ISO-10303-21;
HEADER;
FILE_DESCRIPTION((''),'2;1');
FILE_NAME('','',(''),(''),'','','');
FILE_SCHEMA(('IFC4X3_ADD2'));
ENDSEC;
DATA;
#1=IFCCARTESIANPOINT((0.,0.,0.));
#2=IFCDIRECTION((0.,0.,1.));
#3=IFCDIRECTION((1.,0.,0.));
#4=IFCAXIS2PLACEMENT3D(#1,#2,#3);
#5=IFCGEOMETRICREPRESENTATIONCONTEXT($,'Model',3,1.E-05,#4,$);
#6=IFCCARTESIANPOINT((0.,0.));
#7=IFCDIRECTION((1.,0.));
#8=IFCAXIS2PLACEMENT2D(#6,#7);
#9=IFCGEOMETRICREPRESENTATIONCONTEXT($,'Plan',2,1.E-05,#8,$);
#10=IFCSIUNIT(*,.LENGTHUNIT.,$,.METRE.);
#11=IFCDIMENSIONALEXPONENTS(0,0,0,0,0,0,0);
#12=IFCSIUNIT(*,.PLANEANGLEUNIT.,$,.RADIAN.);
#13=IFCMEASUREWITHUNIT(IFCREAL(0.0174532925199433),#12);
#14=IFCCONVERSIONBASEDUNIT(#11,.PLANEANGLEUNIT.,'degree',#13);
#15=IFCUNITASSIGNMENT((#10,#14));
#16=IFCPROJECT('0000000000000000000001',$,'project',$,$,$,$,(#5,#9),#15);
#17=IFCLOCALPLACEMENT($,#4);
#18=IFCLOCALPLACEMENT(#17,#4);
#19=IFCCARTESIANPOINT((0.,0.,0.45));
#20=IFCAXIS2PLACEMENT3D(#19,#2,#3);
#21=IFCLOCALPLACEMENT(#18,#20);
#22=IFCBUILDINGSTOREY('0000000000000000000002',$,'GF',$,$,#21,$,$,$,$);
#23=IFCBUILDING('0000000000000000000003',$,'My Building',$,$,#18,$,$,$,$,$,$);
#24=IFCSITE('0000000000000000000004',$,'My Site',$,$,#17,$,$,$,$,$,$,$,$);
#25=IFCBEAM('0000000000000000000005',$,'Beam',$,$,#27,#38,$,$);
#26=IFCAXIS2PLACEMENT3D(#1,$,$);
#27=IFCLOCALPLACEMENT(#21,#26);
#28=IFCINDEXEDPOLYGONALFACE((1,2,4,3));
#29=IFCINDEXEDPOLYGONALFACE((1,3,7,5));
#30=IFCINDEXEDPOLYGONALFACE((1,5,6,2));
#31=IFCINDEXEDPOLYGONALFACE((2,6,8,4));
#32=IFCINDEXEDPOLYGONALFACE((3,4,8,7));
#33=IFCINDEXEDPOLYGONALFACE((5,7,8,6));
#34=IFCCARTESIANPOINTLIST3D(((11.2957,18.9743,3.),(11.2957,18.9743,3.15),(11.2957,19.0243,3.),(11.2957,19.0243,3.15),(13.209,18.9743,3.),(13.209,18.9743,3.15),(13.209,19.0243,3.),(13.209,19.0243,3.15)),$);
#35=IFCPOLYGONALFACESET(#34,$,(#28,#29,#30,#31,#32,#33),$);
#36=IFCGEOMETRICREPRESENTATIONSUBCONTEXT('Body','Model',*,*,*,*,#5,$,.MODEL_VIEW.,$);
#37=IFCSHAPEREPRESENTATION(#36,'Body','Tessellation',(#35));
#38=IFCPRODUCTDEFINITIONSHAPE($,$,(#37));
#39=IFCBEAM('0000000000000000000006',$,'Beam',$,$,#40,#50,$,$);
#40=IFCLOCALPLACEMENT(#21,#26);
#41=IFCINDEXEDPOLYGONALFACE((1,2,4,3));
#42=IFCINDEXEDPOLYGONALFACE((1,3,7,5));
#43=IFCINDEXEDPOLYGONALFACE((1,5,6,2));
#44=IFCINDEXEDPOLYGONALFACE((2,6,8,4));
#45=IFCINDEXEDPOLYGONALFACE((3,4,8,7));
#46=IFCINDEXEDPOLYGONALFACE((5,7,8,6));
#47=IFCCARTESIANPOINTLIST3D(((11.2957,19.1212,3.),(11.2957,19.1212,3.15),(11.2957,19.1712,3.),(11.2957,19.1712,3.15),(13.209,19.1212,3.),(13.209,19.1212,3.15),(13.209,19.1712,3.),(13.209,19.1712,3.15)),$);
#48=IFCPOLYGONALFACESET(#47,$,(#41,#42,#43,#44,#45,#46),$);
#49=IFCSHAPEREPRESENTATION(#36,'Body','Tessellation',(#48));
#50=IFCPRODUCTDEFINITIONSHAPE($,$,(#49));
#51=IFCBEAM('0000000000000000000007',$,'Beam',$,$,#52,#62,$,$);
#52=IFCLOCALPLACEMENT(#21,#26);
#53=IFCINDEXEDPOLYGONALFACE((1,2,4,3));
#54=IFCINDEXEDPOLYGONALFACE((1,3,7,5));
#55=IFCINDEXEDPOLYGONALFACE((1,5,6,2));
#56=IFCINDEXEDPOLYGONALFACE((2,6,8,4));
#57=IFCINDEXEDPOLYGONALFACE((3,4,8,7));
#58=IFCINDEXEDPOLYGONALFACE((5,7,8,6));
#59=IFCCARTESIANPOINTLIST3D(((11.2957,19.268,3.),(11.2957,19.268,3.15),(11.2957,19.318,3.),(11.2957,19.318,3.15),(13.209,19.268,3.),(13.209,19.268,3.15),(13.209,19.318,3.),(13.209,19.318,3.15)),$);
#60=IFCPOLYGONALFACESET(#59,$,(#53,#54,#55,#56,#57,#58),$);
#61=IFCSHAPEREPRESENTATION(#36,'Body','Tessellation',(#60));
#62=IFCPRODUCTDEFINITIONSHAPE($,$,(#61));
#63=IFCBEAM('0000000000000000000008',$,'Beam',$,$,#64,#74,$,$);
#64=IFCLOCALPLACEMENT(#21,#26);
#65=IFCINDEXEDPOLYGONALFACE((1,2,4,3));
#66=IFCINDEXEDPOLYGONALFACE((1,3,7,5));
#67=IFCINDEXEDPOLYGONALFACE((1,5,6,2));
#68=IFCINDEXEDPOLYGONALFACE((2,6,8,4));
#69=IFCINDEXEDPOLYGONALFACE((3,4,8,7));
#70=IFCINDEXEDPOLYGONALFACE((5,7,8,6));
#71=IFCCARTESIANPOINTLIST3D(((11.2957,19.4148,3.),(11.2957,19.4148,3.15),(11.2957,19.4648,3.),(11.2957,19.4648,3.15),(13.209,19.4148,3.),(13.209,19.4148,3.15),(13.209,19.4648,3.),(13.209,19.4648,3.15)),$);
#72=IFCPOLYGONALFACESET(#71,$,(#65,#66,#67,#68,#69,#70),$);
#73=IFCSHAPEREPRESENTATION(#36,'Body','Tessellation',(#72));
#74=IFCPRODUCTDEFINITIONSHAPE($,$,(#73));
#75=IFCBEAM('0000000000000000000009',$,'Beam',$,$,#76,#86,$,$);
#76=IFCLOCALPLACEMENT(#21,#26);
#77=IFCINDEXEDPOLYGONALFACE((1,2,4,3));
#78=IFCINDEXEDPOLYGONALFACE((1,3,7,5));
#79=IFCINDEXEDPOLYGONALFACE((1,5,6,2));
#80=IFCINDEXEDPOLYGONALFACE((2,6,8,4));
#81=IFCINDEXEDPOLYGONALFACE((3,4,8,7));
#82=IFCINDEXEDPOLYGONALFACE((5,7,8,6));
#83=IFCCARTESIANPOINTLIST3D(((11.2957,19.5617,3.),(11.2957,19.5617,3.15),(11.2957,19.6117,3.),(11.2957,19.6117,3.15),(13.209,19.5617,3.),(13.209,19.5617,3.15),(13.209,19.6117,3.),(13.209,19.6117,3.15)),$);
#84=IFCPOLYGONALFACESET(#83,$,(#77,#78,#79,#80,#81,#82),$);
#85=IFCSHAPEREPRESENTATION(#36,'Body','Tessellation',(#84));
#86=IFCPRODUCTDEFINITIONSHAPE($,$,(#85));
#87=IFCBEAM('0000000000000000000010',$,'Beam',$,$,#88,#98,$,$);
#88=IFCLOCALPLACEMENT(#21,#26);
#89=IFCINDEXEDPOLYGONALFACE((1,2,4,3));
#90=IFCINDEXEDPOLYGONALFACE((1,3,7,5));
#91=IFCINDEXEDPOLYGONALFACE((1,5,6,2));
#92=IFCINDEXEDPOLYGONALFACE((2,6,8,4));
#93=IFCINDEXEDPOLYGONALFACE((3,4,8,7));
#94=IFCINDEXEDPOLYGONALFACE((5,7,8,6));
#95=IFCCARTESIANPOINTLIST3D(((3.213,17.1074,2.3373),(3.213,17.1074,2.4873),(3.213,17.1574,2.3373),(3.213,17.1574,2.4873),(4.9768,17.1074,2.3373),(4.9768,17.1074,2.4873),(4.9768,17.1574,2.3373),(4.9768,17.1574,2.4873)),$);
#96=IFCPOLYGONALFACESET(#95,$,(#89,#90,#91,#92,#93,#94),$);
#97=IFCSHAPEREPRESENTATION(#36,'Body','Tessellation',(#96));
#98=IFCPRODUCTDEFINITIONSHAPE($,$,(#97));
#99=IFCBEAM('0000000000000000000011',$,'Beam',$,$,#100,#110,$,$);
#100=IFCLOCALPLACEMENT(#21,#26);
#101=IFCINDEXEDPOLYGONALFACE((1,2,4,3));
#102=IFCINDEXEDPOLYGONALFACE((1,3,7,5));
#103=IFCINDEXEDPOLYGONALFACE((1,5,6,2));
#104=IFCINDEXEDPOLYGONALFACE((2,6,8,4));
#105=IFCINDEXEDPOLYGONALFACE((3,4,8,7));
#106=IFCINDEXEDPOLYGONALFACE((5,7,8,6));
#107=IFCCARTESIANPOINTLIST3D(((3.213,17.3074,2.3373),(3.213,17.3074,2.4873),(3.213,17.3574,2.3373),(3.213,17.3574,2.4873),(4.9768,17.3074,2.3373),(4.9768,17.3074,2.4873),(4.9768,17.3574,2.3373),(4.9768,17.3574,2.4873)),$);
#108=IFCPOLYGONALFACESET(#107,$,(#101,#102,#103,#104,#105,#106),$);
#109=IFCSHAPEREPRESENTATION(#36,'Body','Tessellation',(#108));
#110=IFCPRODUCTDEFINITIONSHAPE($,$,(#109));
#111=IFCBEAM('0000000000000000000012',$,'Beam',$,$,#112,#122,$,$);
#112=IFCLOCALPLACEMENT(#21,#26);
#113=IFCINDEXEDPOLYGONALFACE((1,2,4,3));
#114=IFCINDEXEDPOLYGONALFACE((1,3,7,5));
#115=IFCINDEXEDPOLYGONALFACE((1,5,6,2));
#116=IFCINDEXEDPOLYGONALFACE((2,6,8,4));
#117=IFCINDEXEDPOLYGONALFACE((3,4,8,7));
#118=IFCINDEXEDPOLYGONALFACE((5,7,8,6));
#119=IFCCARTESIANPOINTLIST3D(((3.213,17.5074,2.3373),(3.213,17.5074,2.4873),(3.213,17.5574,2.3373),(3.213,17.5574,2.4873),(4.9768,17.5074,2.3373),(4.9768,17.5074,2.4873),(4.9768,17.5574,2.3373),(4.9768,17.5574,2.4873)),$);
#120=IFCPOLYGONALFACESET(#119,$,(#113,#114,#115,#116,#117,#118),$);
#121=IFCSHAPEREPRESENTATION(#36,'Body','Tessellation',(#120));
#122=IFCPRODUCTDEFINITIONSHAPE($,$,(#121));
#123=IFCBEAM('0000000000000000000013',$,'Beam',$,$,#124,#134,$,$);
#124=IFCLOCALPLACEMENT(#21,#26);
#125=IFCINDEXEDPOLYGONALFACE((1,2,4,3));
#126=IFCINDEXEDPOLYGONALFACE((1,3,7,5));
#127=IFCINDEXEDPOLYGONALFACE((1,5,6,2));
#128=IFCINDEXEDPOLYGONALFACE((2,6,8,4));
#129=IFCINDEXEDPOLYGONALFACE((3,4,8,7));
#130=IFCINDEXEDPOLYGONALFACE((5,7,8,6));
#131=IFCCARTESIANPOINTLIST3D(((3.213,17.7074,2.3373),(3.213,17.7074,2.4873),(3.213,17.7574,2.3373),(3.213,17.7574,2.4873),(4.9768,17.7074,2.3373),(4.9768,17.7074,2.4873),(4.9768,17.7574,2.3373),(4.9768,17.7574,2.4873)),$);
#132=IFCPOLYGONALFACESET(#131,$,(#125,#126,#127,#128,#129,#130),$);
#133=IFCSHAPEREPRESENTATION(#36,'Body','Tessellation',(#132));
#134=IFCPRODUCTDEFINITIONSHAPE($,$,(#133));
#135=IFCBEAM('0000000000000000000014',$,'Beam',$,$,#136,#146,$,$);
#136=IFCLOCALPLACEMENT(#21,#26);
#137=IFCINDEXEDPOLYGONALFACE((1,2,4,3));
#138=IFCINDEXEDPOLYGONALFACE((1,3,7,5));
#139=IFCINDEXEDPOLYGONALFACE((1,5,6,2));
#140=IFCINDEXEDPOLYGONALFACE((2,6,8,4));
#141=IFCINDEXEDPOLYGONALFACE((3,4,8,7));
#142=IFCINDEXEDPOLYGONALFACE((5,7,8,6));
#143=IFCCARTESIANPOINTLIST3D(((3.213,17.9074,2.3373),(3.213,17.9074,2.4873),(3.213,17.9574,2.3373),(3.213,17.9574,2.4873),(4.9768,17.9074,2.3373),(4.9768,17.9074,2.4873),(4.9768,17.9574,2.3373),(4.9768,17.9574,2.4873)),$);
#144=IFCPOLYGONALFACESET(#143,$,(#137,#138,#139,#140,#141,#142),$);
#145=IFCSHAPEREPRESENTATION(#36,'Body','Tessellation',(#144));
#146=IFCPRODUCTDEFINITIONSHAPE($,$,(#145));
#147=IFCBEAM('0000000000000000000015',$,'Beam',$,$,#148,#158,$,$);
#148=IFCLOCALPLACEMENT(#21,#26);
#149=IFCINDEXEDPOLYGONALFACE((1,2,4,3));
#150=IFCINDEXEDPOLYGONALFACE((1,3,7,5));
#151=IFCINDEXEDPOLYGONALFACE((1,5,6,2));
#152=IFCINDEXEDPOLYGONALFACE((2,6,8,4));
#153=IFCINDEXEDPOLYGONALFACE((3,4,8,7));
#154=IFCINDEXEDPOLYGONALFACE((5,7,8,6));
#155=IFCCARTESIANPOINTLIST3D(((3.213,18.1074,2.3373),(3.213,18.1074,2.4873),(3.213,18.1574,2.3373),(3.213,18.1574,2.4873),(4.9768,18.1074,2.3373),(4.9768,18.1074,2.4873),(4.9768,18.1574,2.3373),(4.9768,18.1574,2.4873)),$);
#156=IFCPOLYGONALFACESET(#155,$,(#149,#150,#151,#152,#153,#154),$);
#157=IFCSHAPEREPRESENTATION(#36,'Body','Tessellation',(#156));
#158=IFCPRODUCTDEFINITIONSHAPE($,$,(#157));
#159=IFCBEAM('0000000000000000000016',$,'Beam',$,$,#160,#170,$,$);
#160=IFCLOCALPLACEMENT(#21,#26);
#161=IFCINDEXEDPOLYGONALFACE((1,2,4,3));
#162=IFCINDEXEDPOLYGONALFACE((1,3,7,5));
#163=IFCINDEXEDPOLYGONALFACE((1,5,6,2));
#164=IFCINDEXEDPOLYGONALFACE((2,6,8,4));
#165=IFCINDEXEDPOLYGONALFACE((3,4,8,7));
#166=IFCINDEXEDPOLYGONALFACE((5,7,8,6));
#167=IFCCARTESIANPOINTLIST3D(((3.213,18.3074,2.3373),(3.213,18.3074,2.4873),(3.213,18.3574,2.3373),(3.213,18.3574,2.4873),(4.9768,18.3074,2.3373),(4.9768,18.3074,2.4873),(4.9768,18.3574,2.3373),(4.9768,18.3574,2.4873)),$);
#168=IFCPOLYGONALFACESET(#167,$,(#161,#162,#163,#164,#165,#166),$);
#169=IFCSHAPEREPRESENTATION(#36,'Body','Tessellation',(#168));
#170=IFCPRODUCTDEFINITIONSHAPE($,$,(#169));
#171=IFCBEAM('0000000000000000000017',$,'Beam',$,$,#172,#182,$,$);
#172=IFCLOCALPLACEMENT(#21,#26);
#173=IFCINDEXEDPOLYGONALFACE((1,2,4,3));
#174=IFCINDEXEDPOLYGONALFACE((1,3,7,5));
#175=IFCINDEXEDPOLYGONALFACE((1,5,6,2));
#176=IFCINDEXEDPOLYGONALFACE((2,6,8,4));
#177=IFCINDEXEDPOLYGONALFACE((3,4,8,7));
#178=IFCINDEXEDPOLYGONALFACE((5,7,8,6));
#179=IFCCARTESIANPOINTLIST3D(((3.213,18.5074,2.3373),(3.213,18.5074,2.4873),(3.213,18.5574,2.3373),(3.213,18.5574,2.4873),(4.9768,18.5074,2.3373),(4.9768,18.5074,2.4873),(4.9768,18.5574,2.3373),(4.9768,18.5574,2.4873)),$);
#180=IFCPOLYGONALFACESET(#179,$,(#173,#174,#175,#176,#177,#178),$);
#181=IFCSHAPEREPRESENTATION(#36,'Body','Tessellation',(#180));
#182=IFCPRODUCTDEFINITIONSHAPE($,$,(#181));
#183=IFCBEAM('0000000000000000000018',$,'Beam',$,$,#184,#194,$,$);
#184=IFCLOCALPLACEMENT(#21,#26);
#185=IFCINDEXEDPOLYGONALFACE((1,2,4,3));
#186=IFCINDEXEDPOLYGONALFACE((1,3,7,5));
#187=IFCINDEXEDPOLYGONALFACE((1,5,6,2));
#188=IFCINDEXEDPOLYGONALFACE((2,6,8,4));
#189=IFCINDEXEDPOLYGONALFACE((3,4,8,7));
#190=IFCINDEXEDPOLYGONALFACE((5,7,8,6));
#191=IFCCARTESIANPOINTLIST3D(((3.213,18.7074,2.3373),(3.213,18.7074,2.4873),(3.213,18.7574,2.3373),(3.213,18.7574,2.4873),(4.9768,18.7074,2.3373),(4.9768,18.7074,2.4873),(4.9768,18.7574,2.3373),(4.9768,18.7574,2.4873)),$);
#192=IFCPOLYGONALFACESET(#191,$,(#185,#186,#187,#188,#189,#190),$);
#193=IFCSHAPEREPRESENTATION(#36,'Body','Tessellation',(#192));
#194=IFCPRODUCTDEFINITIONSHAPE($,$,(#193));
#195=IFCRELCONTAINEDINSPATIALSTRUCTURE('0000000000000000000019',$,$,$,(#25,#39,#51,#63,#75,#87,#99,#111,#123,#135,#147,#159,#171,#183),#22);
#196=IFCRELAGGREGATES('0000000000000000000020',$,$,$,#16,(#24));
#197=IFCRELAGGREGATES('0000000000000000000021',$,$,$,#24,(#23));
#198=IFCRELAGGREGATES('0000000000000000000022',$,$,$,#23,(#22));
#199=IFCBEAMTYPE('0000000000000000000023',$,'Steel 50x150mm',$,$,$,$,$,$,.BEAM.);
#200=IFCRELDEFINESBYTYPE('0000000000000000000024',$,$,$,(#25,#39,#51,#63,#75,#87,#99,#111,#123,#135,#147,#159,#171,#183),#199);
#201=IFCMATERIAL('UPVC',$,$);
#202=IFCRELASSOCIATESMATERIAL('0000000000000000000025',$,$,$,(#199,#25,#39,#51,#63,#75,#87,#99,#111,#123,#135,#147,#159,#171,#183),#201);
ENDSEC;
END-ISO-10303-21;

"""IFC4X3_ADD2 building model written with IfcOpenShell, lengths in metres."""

from ifc_helpers import new_model, entity, si_unit, converted_unit, frame, origin_with_axes, origin_2d_with_axis, place, context, subcontext, project, spatial, rectangle, extrude, material, material_profile, profile_set, profile_usage, type_object, element, save


model = new_model("IFC4X3_ADD2")

# Units and contexts
model_context = context("Model", 3, precision=1e-05, world=origin_with_axes())
plan_context = context("Plan", 2, precision=1e-05, world=origin_2d_with_axis())
body_context = subcontext(model_context, "Body", "Model", "MODEL_VIEW")
ifc_project = project(units=[si_unit("LENGTHUNIT", "METRE"), converted_unit("PLANEANGLEUNIT", "degree", entity("IfcReal", 0.0174532925199433), si_unit("PLANEANGLEUNIT", "RADIAN"), dimensions=[0, 0, 0, 0, 0, 0, 0])], contexts=[model_context, plan_context])

# Site, building, storey
site_placement = place(None, origin_with_axes())
site = spatial("IfcSite", under=ifc_project, at=site_placement, Name="My Site")
building_placement = place(site_placement, origin_with_axes())
building = spatial("IfcBuilding", under=site, at=building_placement, Name="My Building")
storey_placement = place(building_placement, frame((0.0, 0.0, 0.45), z_axis=(0.0, 0.0, 1.0), x_axis=(1.0, 0.0, 0.0)))
storey = spatial("IfcBuildingStorey", under=building, at=storey_placement, Name="GF")

# Beams
ifc_material = material(Name="UPVC")
ifc_material_profile = material_profile(ifc_material, rectangle(XDim=0.05, YDim=0.15))
ifc_profile_set = profile_set([ifc_material_profile])
beam_type = type_object("IfcBeamType", Name="Steel 50x150mm", PredefinedType="BEAM", material=ifc_profile_set)
ifc_profile_usage_1 = profile_usage(ifc_profile_set)
beam_1_placement = place(storey_placement, frame((11.2957, 18.9993, 3.075), z_axis=(1.0, 0.0, 0.0), x_axis=(0.0, 1.0, 0.0)))
element("IfcBeam", 1, at=beam_1_placement, inside=storey, type_object=beam_type, material=ifc_profile_usage_1, Name="Beam", context=body_context, shape_type="SweptSolid", body=[
    extrude(rectangle(XDim=0.05, YDim=0.15), origin_with_axes(), (0.0, 0.0, 1.0), 1.9133),
])
ifc_profile_usage_2 = profile_usage(ifc_profile_set)
beam_2_placement = place(storey_placement, frame((11.2957, 19.1462, 3.075), z_axis=(1.0, 0.0, 0.0), x_axis=(0.0, 1.0, 0.0)))
element("IfcBeam", 2, at=beam_2_placement, inside=storey, type_object=beam_type, material=ifc_profile_usage_2, Name="Beam", context=body_context, shape_type="SweptSolid", body=[
    extrude(rectangle(XDim=0.05, YDim=0.15), origin_with_axes(), (0.0, 0.0, 1.0), 1.9133),
])
ifc_profile_usage_3 = profile_usage(ifc_profile_set)
beam_3_placement = place(storey_placement, frame((11.2957, 19.293, 3.075), z_axis=(1.0, 0.0, 0.0), x_axis=(0.0, 1.0, 0.0)))
element("IfcBeam", 3, at=beam_3_placement, inside=storey, type_object=beam_type, material=ifc_profile_usage_3, Name="Beam", context=body_context, shape_type="SweptSolid", body=[
    extrude(rectangle(XDim=0.05, YDim=0.15), origin_with_axes(), (0.0, 0.0, 1.0), 1.9133),
])
ifc_profile_usage_4 = profile_usage(ifc_profile_set)
beam_4_placement = place(storey_placement, frame((11.2957, 19.4398, 3.075), z_axis=(1.0, 0.0, 0.0), x_axis=(0.0, 1.0, 0.0)))
element("IfcBeam", 4, at=beam_4_placement, inside=storey, type_object=beam_type, material=ifc_profile_usage_4, Name="Beam", context=body_context, shape_type="SweptSolid", body=[
    extrude(rectangle(XDim=0.05, YDim=0.15), origin_with_axes(), (0.0, 0.0, 1.0), 1.9133),
])
ifc_profile_usage_5 = profile_usage(ifc_profile_set)
beam_5_placement = place(storey_placement, frame((11.2957, 19.5867, 3.075), z_axis=(1.0, 0.0, 0.0), x_axis=(0.0, 1.0, 0.0)))
element("IfcBeam", 5, at=beam_5_placement, inside=storey, type_object=beam_type, material=ifc_profile_usage_5, Name="Beam", context=body_context, shape_type="SweptSolid", body=[
    extrude(rectangle(XDim=0.05, YDim=0.15), origin_with_axes(), (0.0, 0.0, 1.0), 1.9133),
])
ifc_profile_usage_6 = profile_usage(ifc_profile_set)
beam_6_placement = place(storey_placement, frame((3.213, 17.1324, 2.4123), z_axis=(1.0, 0.0, 0.0), x_axis=(0.0, 1.0, 0.0)))
element("IfcBeam", 6, at=beam_6_placement, inside=storey, type_object=beam_type, material=ifc_profile_usage_6, Name="Beam", context=body_context, shape_type="SweptSolid", body=[
    extrude(rectangle(XDim=0.05, YDim=0.15), origin_with_axes(), (0.0, 0.0, 1.0), 1.7638),
])
ifc_profile_usage_7 = profile_usage(ifc_profile_set)
beam_7_placement = place(storey_placement, frame((3.213, 17.3324, 2.4123), z_axis=(1.0, 0.0, 0.0), x_axis=(0.0, 1.0, 0.0)))
element("IfcBeam", 7, at=beam_7_placement, inside=storey, type_object=beam_type, material=ifc_profile_usage_7, Name="Beam", context=body_context, shape_type="SweptSolid", body=[
    extrude(rectangle(XDim=0.05, YDim=0.15), origin_with_axes(), (0.0, 0.0, 1.0), 1.7638),
])
ifc_profile_usage_8 = profile_usage(ifc_profile_set)
beam_8_placement = place(storey_placement, frame((3.213, 17.5324, 2.4123), z_axis=(1.0, 0.0, 0.0), x_axis=(0.0, 1.0, 0.0)))
element("IfcBeam", 8, at=beam_8_placement, inside=storey, type_object=beam_type, material=ifc_profile_usage_8, Name="Beam", context=body_context, shape_type="SweptSolid", body=[
    extrude(rectangle(XDim=0.05, YDim=0.15), origin_with_axes(), (0.0, 0.0, 1.0), 1.7638),
])
ifc_profile_usage_9 = profile_usage(ifc_profile_set)
beam_9_placement = place(storey_placement, frame((3.213, 17.7324, 2.4123), z_axis=(1.0, 0.0, 0.0), x_axis=(0.0, 1.0, 0.0)))
element("IfcBeam", 9, at=beam_9_placement, inside=storey, type_object=beam_type, material=ifc_profile_usage_9, Name="Beam", context=body_context, shape_type="SweptSolid", body=[
    extrude(rectangle(XDim=0.05, YDim=0.15), origin_with_axes(), (0.0, 0.0, 1.0), 1.7638),
])
ifc_profile_usage_10 = profile_usage(ifc_profile_set)
beam_10_placement = place(storey_placement, frame((3.213, 17.9324, 2.4123), z_axis=(1.0, 0.0, 0.0), x_axis=(0.0, 1.0, 0.0)))
element("IfcBeam", 10, at=beam_10_placement, inside=storey, type_object=beam_type, material=ifc_profile_usage_10, Name="Beam", context=body_context, shape_type="SweptSolid", body=[
    extrude(rectangle(XDim=0.05, YDim=0.15), origin_with_axes(), (0.0, 0.0, 1.0), 1.7638),
])
ifc_profile_usage_11 = profile_usage(ifc_profile_set)
beam_11_placement = place(storey_placement, frame((3.213, 18.1324, 2.4123), z_axis=(1.0, 0.0, 0.0), x_axis=(0.0, 1.0, 0.0)))
element("IfcBeam", 11, at=beam_11_placement, inside=storey, type_object=beam_type, material=ifc_profile_usage_11, Name="Beam", context=body_context, shape_type="SweptSolid", body=[
    extrude(rectangle(XDim=0.05, YDim=0.15), origin_with_axes(), (0.0, 0.0, 1.0), 1.7638),
])
ifc_profile_usage_12 = profile_usage(ifc_profile_set)
beam_12_placement = place(storey_placement, frame((3.213, 18.3324, 2.4123), z_axis=(1.0, 0.0, 0.0), x_axis=(0.0, 1.0, 0.0)))
element("IfcBeam", 12, at=beam_12_placement, inside=storey, type_object=beam_type, material=ifc_profile_usage_12, Name="Beam", context=body_context, shape_type="SweptSolid", body=[
    extrude(rectangle(XDim=0.05, YDim=0.15), origin_with_axes(), (0.0, 0.0, 1.0), 1.7638),
])
ifc_profile_usage_13 = profile_usage(ifc_profile_set)
beam_13_placement = place(storey_placement, frame((3.213, 18.5324, 2.4123), z_axis=(1.0, 0.0, 0.0), x_axis=(0.0, 1.0, 0.0)))
element("IfcBeam", 13, at=beam_13_placement, inside=storey, type_object=beam_type, material=ifc_profile_usage_13, Name="Beam", context=body_context, shape_type="SweptSolid", body=[
    extrude(rectangle(XDim=0.05, YDim=0.15), origin_with_axes(), (0.0, 0.0, 1.0), 1.7638),
])
ifc_profile_usage_14 = profile_usage(ifc_profile_set)
beam_14_placement = place(storey_placement, frame((3.213, 18.7324, 2.4123), z_axis=(1.0, 0.0, 0.0), x_axis=(0.0, 1.0, 0.0)))
element("IfcBeam", 14, at=beam_14_placement, inside=storey, type_object=beam_type, material=ifc_profile_usage_14, Name="Beam", context=body_context, shape_type="SweptSolid", body=[
    extrude(rectangle(XDim=0.05, YDim=0.15), origin_with_axes(), (0.0, 0.0, 1.0), 1.7638),
])

save(model, "model.ifc")
